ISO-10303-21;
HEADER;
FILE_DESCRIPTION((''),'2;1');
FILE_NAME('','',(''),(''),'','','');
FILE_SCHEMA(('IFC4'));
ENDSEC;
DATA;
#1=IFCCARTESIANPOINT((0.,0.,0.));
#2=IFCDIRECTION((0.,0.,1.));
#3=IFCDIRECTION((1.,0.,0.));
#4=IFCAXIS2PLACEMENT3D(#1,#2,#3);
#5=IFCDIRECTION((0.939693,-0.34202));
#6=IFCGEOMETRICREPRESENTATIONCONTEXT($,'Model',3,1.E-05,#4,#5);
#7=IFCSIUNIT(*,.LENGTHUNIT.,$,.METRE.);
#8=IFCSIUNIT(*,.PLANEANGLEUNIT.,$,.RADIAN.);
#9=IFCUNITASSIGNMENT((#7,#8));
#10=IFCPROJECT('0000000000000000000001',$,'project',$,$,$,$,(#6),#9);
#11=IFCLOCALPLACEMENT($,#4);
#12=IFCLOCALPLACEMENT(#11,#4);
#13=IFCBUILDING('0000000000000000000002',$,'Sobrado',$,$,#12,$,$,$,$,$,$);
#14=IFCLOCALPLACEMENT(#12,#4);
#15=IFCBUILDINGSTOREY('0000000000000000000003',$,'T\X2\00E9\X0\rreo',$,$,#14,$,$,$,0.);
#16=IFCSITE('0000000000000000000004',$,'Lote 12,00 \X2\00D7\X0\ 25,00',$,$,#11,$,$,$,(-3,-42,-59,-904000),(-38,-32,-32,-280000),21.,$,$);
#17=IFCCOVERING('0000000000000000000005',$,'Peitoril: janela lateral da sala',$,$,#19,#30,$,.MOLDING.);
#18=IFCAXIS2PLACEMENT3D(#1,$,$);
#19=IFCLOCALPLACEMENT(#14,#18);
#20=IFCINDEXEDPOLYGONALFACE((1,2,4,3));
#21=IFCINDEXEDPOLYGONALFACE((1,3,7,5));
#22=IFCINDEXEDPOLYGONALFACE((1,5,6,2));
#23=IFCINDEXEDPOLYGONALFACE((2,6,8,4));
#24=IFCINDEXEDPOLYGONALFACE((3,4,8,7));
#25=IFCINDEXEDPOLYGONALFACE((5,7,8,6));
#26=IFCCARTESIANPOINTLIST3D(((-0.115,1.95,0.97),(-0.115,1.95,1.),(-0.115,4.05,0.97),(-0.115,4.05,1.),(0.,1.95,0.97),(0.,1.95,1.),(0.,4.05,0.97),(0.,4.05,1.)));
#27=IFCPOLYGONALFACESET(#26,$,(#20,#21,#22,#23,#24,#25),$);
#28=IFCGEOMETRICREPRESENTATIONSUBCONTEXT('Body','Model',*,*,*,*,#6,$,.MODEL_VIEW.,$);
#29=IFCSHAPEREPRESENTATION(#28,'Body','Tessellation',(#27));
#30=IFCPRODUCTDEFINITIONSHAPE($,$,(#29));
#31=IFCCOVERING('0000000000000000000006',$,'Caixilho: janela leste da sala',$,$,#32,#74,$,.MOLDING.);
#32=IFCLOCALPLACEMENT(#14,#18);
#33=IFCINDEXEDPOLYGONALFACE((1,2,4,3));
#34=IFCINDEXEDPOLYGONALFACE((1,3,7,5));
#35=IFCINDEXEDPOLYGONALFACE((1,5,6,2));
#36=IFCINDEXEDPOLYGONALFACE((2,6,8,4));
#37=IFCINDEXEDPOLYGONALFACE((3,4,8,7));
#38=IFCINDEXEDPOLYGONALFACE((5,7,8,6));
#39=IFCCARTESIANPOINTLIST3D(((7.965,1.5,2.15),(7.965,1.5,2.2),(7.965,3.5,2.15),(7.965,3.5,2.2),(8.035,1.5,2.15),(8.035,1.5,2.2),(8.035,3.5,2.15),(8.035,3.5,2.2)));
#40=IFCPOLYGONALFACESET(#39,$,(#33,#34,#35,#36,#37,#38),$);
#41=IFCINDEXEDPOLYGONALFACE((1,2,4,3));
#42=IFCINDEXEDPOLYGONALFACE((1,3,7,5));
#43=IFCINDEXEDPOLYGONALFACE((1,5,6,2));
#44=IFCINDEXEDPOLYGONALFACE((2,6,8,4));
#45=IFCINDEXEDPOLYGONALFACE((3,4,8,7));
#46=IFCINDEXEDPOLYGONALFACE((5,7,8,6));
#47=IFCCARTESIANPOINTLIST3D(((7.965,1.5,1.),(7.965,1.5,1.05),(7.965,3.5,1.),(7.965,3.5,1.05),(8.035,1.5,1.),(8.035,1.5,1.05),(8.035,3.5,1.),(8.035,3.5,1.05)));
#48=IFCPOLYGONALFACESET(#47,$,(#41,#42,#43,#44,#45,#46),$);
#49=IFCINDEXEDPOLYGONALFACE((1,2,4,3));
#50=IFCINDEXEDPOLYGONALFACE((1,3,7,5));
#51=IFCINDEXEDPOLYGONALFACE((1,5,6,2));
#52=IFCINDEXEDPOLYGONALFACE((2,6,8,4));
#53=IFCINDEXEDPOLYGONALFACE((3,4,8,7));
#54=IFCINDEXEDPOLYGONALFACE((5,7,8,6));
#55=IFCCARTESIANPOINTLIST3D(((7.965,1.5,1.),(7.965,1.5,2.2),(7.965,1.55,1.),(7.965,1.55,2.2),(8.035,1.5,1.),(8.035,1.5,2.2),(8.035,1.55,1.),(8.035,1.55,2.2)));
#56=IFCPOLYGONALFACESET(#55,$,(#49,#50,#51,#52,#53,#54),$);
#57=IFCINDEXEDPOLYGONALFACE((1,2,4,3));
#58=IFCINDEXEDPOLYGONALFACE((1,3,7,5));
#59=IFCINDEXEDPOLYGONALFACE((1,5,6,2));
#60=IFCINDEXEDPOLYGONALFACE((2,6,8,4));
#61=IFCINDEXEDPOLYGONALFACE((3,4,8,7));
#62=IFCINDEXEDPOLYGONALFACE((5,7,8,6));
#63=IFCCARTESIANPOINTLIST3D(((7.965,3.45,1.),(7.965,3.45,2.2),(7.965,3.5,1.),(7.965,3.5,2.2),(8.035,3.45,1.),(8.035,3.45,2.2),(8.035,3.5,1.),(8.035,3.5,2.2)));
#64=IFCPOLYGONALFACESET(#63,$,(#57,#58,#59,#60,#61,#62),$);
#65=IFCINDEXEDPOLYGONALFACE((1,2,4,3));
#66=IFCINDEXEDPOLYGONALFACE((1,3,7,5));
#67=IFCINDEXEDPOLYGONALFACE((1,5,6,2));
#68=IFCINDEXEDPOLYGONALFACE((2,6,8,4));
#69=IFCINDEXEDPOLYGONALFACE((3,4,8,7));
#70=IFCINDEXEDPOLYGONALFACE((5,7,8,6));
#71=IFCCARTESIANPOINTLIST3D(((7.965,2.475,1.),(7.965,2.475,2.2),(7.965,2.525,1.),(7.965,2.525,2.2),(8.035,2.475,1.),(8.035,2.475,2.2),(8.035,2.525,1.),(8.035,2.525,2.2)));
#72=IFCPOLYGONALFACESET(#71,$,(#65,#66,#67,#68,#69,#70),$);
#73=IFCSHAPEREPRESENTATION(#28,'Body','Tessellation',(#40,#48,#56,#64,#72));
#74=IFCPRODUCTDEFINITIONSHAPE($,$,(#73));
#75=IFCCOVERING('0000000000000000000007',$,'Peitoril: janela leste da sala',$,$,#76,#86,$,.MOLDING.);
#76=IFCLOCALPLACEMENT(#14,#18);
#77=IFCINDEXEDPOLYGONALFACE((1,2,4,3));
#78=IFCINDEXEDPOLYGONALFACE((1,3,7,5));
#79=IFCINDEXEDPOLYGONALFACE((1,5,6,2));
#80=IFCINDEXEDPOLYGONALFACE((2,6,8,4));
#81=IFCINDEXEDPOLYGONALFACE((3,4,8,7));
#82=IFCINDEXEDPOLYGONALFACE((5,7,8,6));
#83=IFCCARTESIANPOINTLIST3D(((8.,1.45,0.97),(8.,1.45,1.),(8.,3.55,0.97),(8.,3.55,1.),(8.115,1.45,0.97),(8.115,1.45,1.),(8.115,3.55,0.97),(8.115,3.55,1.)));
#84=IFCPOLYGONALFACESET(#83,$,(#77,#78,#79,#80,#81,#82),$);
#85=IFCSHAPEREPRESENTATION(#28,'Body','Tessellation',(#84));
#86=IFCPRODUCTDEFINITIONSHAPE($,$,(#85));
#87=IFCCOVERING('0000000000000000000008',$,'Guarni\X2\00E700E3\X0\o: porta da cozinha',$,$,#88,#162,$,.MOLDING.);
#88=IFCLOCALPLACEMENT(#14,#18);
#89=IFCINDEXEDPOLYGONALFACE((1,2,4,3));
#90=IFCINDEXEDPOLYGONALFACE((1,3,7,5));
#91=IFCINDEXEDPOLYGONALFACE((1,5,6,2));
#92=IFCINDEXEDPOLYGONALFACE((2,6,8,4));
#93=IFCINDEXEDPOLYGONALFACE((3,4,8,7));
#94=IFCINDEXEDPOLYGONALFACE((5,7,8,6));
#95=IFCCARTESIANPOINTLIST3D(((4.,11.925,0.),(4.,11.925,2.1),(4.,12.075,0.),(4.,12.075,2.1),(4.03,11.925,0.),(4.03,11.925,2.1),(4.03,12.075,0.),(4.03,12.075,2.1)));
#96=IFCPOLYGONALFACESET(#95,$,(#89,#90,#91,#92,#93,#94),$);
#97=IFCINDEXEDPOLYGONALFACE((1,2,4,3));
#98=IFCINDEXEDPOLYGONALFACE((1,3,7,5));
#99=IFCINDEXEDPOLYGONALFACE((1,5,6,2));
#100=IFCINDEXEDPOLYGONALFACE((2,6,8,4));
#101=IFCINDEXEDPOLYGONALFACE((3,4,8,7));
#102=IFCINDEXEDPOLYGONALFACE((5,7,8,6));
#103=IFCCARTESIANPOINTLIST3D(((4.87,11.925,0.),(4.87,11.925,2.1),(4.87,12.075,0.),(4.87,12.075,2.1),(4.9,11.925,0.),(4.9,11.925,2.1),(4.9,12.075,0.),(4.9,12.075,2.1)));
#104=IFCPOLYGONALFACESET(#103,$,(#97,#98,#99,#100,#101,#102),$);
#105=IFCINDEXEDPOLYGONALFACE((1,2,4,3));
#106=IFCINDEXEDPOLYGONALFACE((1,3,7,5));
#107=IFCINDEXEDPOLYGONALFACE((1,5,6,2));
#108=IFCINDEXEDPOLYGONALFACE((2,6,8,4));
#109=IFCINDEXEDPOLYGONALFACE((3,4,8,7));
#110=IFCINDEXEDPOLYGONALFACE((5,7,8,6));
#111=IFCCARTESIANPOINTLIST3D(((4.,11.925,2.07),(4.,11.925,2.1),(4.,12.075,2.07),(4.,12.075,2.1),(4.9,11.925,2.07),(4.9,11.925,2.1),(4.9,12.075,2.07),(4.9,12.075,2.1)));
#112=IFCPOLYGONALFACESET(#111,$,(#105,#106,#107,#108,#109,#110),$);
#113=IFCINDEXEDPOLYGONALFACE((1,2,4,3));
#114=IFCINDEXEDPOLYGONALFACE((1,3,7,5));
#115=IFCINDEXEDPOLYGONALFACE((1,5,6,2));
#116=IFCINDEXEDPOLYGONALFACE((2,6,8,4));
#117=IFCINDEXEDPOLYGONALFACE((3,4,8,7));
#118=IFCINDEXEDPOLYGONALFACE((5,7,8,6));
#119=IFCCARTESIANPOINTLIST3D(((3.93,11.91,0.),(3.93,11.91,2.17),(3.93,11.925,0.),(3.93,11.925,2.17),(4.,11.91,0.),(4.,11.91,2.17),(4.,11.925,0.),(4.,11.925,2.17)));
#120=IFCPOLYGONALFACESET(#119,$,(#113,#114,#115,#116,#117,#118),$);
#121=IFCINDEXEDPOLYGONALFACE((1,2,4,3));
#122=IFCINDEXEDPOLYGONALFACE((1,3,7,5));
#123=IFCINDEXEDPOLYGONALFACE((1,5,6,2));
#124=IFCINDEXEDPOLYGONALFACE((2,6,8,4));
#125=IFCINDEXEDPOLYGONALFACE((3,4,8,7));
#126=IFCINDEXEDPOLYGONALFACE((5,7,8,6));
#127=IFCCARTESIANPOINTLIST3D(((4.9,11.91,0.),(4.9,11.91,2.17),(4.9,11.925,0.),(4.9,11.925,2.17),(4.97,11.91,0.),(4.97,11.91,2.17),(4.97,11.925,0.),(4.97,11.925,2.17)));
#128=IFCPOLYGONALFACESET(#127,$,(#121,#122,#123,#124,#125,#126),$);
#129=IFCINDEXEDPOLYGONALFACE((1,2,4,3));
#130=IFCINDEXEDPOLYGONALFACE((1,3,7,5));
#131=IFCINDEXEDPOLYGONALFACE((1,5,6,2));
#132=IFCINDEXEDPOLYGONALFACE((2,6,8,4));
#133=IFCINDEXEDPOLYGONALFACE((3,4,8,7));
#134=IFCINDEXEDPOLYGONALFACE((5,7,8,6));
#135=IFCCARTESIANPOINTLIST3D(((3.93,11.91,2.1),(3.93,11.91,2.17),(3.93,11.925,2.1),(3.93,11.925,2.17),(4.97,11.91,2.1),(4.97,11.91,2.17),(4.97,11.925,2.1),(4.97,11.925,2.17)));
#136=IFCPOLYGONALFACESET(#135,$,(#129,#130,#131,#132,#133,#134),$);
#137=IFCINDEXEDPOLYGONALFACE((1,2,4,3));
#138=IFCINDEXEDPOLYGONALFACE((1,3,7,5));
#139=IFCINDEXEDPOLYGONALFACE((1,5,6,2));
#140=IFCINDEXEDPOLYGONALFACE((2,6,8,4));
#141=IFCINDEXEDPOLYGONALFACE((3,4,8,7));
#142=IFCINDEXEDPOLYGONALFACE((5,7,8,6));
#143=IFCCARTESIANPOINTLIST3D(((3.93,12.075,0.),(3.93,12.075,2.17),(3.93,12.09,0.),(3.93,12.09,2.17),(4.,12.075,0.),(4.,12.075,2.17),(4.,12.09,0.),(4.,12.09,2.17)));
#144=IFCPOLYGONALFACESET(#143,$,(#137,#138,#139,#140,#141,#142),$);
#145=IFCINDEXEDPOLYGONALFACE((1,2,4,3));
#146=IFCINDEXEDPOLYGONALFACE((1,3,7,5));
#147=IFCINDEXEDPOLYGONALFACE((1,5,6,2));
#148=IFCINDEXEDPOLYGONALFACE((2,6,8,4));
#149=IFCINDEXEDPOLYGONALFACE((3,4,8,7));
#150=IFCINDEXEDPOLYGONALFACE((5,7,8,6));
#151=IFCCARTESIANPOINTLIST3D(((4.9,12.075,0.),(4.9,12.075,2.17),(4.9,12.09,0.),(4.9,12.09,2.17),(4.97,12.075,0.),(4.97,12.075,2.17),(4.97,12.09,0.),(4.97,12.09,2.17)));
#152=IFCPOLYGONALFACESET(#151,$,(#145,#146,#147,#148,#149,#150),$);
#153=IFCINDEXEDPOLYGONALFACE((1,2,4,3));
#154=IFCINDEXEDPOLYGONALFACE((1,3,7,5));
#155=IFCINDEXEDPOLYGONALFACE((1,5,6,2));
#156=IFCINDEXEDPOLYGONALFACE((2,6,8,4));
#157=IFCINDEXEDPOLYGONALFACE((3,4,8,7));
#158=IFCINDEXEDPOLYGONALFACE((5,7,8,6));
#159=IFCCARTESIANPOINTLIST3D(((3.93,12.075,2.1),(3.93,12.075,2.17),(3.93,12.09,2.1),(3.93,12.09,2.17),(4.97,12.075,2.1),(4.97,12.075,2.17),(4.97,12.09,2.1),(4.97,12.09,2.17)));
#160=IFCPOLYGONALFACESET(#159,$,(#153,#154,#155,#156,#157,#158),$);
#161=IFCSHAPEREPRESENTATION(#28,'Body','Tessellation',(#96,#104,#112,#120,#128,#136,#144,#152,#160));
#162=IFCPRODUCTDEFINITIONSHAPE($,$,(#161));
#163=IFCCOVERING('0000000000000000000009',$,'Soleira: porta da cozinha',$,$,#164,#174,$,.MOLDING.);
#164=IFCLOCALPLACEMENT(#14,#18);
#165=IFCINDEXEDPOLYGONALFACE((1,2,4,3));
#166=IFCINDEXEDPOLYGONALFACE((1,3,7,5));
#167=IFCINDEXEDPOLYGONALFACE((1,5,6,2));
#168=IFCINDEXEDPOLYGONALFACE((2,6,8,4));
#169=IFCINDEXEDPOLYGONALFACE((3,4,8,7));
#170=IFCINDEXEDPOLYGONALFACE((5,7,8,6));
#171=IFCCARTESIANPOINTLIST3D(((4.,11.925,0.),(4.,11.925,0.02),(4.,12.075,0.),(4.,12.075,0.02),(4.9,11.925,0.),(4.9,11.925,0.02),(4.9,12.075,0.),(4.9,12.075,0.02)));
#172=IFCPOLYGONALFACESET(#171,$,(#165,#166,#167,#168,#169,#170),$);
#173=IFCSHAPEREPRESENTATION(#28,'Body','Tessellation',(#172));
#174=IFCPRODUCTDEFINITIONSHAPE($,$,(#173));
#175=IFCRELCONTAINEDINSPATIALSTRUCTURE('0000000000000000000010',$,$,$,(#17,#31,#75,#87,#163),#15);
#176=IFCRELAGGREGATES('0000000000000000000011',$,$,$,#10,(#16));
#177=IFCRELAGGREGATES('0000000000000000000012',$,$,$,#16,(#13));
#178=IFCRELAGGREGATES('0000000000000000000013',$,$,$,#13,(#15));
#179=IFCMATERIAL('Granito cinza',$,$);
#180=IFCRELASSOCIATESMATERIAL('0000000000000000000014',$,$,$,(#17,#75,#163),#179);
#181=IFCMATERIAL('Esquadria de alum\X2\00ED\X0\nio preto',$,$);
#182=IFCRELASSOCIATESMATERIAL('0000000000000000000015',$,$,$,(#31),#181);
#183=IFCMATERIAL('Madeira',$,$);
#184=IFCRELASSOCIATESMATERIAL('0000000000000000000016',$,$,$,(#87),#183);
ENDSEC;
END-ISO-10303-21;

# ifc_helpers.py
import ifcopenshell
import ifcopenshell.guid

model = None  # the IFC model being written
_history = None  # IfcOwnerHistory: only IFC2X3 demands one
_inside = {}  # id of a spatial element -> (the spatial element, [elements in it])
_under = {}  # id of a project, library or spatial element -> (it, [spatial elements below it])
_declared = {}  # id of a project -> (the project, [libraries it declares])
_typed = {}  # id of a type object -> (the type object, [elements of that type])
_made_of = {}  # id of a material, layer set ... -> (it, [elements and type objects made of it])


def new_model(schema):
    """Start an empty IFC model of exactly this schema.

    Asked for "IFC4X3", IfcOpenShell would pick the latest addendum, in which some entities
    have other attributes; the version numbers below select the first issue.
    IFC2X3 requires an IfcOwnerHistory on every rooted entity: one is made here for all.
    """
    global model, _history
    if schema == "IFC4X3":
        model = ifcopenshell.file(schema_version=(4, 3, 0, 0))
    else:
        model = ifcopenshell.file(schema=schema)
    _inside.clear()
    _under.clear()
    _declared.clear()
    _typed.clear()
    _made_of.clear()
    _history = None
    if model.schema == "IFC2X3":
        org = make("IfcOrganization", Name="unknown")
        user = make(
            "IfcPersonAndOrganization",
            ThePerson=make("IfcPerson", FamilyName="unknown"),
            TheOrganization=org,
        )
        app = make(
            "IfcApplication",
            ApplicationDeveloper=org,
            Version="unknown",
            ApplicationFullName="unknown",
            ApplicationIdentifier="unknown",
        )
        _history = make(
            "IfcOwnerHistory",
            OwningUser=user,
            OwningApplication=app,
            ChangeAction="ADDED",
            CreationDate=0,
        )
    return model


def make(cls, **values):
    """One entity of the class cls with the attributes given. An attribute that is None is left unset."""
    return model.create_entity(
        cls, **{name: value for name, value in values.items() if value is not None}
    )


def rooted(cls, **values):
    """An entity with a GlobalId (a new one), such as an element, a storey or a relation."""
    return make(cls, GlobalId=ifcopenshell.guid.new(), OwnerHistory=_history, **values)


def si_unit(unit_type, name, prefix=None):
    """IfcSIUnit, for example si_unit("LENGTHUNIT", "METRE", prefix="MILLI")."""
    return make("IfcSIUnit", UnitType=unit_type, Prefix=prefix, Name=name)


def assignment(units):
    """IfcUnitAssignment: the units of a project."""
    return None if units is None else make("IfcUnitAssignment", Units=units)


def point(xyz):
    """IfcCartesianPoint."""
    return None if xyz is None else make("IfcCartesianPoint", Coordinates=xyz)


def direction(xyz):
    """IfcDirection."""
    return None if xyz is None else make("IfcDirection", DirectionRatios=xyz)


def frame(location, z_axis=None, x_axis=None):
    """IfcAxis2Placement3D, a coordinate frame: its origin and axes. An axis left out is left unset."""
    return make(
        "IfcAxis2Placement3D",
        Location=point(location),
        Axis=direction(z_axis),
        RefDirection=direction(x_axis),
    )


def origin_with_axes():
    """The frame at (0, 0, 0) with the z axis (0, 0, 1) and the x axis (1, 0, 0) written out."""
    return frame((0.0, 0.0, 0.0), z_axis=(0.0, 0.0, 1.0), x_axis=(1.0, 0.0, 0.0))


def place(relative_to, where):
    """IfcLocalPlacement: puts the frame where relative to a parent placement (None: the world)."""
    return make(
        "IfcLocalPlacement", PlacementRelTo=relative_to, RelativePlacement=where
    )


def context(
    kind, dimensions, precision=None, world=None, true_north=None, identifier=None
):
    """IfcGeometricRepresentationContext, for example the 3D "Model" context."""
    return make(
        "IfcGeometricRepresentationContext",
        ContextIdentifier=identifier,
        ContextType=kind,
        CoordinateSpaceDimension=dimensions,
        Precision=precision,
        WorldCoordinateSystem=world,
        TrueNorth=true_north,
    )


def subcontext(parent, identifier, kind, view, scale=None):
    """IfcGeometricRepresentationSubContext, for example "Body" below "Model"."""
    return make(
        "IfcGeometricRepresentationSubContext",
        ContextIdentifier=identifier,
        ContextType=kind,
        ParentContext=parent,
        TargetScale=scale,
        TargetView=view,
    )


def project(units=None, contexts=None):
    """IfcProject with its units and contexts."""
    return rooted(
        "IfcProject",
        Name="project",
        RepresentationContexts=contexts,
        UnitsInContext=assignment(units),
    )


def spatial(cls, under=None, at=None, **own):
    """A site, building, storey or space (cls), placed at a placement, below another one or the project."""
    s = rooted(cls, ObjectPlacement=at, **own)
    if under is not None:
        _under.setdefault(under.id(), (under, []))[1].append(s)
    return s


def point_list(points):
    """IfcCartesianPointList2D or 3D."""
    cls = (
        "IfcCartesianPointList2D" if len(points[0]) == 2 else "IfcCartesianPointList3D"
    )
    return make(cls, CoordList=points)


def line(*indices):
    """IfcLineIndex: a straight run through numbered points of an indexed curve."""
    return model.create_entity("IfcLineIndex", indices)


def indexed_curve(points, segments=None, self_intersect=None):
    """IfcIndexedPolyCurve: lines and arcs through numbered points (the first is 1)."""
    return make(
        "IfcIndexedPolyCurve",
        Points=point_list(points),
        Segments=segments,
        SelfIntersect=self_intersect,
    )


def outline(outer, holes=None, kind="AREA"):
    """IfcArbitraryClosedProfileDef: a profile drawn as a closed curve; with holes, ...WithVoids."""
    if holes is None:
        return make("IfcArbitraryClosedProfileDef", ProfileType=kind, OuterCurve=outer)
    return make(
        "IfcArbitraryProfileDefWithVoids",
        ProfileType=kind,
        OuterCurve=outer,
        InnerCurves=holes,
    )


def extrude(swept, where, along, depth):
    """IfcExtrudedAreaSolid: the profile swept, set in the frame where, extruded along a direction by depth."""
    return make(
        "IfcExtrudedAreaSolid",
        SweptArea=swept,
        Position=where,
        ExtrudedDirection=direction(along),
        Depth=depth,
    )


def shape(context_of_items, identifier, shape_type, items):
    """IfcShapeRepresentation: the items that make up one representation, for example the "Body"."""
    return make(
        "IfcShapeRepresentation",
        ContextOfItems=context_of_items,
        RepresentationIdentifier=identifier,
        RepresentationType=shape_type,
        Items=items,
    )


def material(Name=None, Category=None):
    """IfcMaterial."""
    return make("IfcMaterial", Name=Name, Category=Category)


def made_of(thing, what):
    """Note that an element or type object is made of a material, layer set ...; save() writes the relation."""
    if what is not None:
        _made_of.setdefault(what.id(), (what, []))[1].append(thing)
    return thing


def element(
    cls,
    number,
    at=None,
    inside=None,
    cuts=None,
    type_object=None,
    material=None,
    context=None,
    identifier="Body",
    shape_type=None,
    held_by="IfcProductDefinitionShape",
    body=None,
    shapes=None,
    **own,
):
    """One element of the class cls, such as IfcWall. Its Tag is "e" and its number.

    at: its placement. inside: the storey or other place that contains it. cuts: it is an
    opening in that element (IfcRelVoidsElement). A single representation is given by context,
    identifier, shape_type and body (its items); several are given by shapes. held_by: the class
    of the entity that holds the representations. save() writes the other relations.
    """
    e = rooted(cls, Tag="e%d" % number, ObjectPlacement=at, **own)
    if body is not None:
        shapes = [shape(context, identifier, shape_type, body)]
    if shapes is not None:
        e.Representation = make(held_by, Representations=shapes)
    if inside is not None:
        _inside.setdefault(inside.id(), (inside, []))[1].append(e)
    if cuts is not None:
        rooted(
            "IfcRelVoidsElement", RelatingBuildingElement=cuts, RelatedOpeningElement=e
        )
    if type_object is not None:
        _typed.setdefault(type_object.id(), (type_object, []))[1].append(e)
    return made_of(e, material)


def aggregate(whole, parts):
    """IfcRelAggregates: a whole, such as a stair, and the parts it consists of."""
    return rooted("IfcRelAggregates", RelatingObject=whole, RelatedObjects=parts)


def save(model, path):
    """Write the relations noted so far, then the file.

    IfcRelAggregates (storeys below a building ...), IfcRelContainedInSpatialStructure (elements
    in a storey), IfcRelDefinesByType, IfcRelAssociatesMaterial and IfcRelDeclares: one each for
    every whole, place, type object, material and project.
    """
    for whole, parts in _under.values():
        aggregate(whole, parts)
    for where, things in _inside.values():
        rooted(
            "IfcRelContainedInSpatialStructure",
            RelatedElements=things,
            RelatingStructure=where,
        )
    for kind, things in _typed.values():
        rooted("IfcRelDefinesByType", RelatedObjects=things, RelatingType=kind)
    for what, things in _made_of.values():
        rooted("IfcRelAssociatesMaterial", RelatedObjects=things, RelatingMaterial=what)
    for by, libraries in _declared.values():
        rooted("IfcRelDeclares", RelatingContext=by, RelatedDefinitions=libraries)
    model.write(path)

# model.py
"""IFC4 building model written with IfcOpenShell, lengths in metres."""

from ifc_helpers import new_model, si_unit, direction, frame, origin_with_axes, place, context, subcontext, project, spatial, line, indexed_curve, outline, extrude, material, element, save


model = new_model("IFC4")

# Units and contexts
model_context = context("Model", 3, precision=1e-05, world=origin_with_axes(), true_north=direction((0.939693, -0.34202)))
body_context = subcontext(model_context, "Body", "Model", "MODEL_VIEW")
ifc_project = project(units=[si_unit("LENGTHUNIT", "METRE"), si_unit("PLANEANGLEUNIT", "RADIAN")], contexts=[model_context])

# Site, building, storey
site_placement = place(None, origin_with_axes())
site = spatial("IfcSite", under=ifc_project, at=site_placement, Name="Lote 12,00 × 25,00", RefLatitude=(-3, -42, -59, -904000), RefLongitude=(-38, -32, -32, -280000), RefElevation=21.0)
building_placement = place(site_placement, origin_with_axes())
building = spatial("IfcBuilding", under=site, at=building_placement, Name="Sobrado")
storey_placement = place(building_placement, origin_with_axes())
storey = spatial("IfcBuildingStorey", under=building, at=storey_placement, Name="Térreo", Elevation=0.0)

# Coverings
ifc_material_1 = material(Name="Madeira")
ifc_material_2 = material(Name="Granito cinza")
ifc_material_3 = material(Name="Esquadria de alumínio preto")
covering_1_placement = place(storey_placement, origin_with_axes())
element("IfcCovering", 1, at=covering_1_placement, inside=storey, material=ifc_material_2, Name="Peitoril: janela lateral da sala", PredefinedType="MOLDING", context=body_context, shape_type="SweptSolid", body=[
    extrude(outline(indexed_curve([(-0.115, 1.95), (0.0, 1.95), (0.0, 4.05), (-0.115, 4.05)], segments=[line(1, 2, 3, 4, 1)])), frame((0.0, 0.0, 0.97), z_axis=(0.0, 0.0, 1.0), x_axis=(1.0, 0.0, 0.0)), (0.0, 0.0, 1.0), 0.03),
])
covering_2_placement = place(storey_placement, origin_with_axes())
element("IfcCovering", 2, at=covering_2_placement, inside=storey, material=ifc_material_3, Name="Caixilho: janela leste da sala", PredefinedType="MOLDING", context=body_context, shape_type="SweptSolid", body=[
    extrude(outline(indexed_curve([(7.965, 1.5), (8.035, 1.5), (8.035, 3.5), (7.965, 3.5)], segments=[line(1, 2, 3, 4, 1)])), frame((0.0, 0.0, 2.15), z_axis=(0.0, 0.0, 1.0), x_axis=(1.0, 0.0, 0.0)), (0.0, 0.0, 1.0), 0.05),
    extrude(outline(indexed_curve([(7.965, 1.5), (8.035, 1.5), (8.035, 3.5), (7.965, 3.5)], segments=[line(1, 2, 3, 4, 1)])), frame((0.0, 0.0, 1.0), z_axis=(0.0, 0.0, 1.0), x_axis=(1.0, 0.0, 0.0)), (0.0, 0.0, 1.0), 0.05),
    extrude(outline(indexed_curve([(7.965, 1.5), (8.035, 1.5), (8.035, 1.55), (7.965, 1.55)], segments=[line(1, 2, 3, 4, 1)])), frame((0.0, 0.0, 1.0), z_axis=(0.0, 0.0, 1.0), x_axis=(1.0, 0.0, 0.0)), (0.0, 0.0, 1.0), 1.2),
    extrude(outline(indexed_curve([(7.965, 3.45), (8.035, 3.45), (8.035, 3.5), (7.965, 3.5)], segments=[line(1, 2, 3, 4, 1)])), frame((0.0, 0.0, 1.0), z_axis=(0.0, 0.0, 1.0), x_axis=(1.0, 0.0, 0.0)), (0.0, 0.0, 1.0), 1.2),
    extrude(outline(indexed_curve([(7.965, 2.475), (8.035, 2.475), (8.035, 2.525), (7.965, 2.525)], segments=[line(1, 2, 3, 4, 1)])), frame((0.0, 0.0, 1.0), z_axis=(0.0, 0.0, 1.0), x_axis=(1.0, 0.0, 0.0)), (0.0, 0.0, 1.0), 1.2),
])
covering_3_placement = place(storey_placement, origin_with_axes())
element("IfcCovering", 3, at=covering_3_placement, inside=storey, material=ifc_material_2, Name="Peitoril: janela leste da sala", PredefinedType="MOLDING", context=body_context, shape_type="SweptSolid", body=[
    extrude(outline(indexed_curve([(8.0, 1.45), (8.115, 1.45), (8.115, 3.55), (8.0, 3.55)], segments=[line(1, 2, 3, 4, 1)])), frame((0.0, 0.0, 0.97), z_axis=(0.0, 0.0, 1.0), x_axis=(1.0, 0.0, 0.0)), (0.0, 0.0, 1.0), 0.03),
])
covering_4_placement = place(storey_placement, origin_with_axes())
element("IfcCovering", 4, at=covering_4_placement, inside=storey, material=ifc_material_1, Name="Guarnição: porta da cozinha", PredefinedType="MOLDING", context=body_context, shape_type="SweptSolid", body=[
    extrude(outline(indexed_curve([(4.0, 11.925), (4.03, 11.925), (4.03, 12.075), (4.0, 12.075)], segments=[line(1, 2, 3, 4, 1)])), origin_with_axes(), (0.0, 0.0, 1.0), 2.1),
    extrude(outline(indexed_curve([(4.87, 11.925), (4.9, 11.925), (4.9, 12.075), (4.87, 12.075)], segments=[line(1, 2, 3, 4, 1)])), origin_with_axes(), (0.0, 0.0, 1.0), 2.1),
    extrude(outline(indexed_curve([(4.0, 11.925), (4.9, 11.925), (4.9, 12.075), (4.0, 12.075)], segments=[line(1, 2, 3, 4, 1)])), frame((0.0, 0.0, 2.07), z_axis=(0.0, 0.0, 1.0), x_axis=(1.0, 0.0, 0.0)), (0.0, 0.0, 1.0), 0.03),
    extrude(outline(indexed_curve([(3.93, 11.91), (4.0, 11.91), (4.0, 11.925), (3.93, 11.925)], segments=[line(1, 2, 3, 4, 1)])), origin_with_axes(), (0.0, 0.0, 1.0), 2.17),
    extrude(outline(indexed_curve([(4.9, 11.91), (4.97, 11.91), (4.97, 11.925), (4.9, 11.925)], segments=[line(1, 2, 3, 4, 1)])), origin_with_axes(), (0.0, 0.0, 1.0), 2.17),
    extrude(outline(indexed_curve([(3.93, 11.91), (4.97, 11.91), (4.97, 11.925), (3.93, 11.925)], segments=[line(1, 2, 3, 4, 1)])), frame((0.0, 0.0, 2.1), z_axis=(0.0, 0.0, 1.0), x_axis=(1.0, 0.0, 0.0)), (0.0, 0.0, 1.0), 0.07),
    extrude(outline(indexed_curve([(3.93, 12.075), (4.0, 12.075), (4.0, 12.09), (3.93, 12.09)], segments=[line(1, 2, 3, 4, 1)])), origin_with_axes(), (0.0, 0.0, 1.0), 2.17),
    extrude(outline(indexed_curve([(4.9, 12.075), (4.97, 12.075), (4.97, 12.09), (4.9, 12.09)], segments=[line(1, 2, 3, 4, 1)])), origin_with_axes(), (0.0, 0.0, 1.0), 2.17),
    extrude(outline(indexed_curve([(3.93, 12.075), (4.97, 12.075), (4.97, 12.09), (3.93, 12.09)], segments=[line(1, 2, 3, 4, 1)])), frame((0.0, 0.0, 2.1), z_axis=(0.0, 0.0, 1.0), x_axis=(1.0, 0.0, 0.0)), (0.0, 0.0, 1.0), 0.07),
])
covering_5_placement = place(storey_placement, origin_with_axes())
element("IfcCovering", 5, at=covering_5_placement, inside=storey, material=ifc_material_2, Name="Soleira: porta da cozinha", PredefinedType="MOLDING", context=body_context, shape_type="SweptSolid", body=[
    extrude(outline(indexed_curve([(4.0, 11.925), (4.9, 11.925), (4.9, 12.075), (4.0, 12.075)], segments=[line(1, 2, 3, 4, 1)])), origin_with_axes(), (0.0, 0.0, 1.0), 0.02),
])

save(model, "model.ifc")
